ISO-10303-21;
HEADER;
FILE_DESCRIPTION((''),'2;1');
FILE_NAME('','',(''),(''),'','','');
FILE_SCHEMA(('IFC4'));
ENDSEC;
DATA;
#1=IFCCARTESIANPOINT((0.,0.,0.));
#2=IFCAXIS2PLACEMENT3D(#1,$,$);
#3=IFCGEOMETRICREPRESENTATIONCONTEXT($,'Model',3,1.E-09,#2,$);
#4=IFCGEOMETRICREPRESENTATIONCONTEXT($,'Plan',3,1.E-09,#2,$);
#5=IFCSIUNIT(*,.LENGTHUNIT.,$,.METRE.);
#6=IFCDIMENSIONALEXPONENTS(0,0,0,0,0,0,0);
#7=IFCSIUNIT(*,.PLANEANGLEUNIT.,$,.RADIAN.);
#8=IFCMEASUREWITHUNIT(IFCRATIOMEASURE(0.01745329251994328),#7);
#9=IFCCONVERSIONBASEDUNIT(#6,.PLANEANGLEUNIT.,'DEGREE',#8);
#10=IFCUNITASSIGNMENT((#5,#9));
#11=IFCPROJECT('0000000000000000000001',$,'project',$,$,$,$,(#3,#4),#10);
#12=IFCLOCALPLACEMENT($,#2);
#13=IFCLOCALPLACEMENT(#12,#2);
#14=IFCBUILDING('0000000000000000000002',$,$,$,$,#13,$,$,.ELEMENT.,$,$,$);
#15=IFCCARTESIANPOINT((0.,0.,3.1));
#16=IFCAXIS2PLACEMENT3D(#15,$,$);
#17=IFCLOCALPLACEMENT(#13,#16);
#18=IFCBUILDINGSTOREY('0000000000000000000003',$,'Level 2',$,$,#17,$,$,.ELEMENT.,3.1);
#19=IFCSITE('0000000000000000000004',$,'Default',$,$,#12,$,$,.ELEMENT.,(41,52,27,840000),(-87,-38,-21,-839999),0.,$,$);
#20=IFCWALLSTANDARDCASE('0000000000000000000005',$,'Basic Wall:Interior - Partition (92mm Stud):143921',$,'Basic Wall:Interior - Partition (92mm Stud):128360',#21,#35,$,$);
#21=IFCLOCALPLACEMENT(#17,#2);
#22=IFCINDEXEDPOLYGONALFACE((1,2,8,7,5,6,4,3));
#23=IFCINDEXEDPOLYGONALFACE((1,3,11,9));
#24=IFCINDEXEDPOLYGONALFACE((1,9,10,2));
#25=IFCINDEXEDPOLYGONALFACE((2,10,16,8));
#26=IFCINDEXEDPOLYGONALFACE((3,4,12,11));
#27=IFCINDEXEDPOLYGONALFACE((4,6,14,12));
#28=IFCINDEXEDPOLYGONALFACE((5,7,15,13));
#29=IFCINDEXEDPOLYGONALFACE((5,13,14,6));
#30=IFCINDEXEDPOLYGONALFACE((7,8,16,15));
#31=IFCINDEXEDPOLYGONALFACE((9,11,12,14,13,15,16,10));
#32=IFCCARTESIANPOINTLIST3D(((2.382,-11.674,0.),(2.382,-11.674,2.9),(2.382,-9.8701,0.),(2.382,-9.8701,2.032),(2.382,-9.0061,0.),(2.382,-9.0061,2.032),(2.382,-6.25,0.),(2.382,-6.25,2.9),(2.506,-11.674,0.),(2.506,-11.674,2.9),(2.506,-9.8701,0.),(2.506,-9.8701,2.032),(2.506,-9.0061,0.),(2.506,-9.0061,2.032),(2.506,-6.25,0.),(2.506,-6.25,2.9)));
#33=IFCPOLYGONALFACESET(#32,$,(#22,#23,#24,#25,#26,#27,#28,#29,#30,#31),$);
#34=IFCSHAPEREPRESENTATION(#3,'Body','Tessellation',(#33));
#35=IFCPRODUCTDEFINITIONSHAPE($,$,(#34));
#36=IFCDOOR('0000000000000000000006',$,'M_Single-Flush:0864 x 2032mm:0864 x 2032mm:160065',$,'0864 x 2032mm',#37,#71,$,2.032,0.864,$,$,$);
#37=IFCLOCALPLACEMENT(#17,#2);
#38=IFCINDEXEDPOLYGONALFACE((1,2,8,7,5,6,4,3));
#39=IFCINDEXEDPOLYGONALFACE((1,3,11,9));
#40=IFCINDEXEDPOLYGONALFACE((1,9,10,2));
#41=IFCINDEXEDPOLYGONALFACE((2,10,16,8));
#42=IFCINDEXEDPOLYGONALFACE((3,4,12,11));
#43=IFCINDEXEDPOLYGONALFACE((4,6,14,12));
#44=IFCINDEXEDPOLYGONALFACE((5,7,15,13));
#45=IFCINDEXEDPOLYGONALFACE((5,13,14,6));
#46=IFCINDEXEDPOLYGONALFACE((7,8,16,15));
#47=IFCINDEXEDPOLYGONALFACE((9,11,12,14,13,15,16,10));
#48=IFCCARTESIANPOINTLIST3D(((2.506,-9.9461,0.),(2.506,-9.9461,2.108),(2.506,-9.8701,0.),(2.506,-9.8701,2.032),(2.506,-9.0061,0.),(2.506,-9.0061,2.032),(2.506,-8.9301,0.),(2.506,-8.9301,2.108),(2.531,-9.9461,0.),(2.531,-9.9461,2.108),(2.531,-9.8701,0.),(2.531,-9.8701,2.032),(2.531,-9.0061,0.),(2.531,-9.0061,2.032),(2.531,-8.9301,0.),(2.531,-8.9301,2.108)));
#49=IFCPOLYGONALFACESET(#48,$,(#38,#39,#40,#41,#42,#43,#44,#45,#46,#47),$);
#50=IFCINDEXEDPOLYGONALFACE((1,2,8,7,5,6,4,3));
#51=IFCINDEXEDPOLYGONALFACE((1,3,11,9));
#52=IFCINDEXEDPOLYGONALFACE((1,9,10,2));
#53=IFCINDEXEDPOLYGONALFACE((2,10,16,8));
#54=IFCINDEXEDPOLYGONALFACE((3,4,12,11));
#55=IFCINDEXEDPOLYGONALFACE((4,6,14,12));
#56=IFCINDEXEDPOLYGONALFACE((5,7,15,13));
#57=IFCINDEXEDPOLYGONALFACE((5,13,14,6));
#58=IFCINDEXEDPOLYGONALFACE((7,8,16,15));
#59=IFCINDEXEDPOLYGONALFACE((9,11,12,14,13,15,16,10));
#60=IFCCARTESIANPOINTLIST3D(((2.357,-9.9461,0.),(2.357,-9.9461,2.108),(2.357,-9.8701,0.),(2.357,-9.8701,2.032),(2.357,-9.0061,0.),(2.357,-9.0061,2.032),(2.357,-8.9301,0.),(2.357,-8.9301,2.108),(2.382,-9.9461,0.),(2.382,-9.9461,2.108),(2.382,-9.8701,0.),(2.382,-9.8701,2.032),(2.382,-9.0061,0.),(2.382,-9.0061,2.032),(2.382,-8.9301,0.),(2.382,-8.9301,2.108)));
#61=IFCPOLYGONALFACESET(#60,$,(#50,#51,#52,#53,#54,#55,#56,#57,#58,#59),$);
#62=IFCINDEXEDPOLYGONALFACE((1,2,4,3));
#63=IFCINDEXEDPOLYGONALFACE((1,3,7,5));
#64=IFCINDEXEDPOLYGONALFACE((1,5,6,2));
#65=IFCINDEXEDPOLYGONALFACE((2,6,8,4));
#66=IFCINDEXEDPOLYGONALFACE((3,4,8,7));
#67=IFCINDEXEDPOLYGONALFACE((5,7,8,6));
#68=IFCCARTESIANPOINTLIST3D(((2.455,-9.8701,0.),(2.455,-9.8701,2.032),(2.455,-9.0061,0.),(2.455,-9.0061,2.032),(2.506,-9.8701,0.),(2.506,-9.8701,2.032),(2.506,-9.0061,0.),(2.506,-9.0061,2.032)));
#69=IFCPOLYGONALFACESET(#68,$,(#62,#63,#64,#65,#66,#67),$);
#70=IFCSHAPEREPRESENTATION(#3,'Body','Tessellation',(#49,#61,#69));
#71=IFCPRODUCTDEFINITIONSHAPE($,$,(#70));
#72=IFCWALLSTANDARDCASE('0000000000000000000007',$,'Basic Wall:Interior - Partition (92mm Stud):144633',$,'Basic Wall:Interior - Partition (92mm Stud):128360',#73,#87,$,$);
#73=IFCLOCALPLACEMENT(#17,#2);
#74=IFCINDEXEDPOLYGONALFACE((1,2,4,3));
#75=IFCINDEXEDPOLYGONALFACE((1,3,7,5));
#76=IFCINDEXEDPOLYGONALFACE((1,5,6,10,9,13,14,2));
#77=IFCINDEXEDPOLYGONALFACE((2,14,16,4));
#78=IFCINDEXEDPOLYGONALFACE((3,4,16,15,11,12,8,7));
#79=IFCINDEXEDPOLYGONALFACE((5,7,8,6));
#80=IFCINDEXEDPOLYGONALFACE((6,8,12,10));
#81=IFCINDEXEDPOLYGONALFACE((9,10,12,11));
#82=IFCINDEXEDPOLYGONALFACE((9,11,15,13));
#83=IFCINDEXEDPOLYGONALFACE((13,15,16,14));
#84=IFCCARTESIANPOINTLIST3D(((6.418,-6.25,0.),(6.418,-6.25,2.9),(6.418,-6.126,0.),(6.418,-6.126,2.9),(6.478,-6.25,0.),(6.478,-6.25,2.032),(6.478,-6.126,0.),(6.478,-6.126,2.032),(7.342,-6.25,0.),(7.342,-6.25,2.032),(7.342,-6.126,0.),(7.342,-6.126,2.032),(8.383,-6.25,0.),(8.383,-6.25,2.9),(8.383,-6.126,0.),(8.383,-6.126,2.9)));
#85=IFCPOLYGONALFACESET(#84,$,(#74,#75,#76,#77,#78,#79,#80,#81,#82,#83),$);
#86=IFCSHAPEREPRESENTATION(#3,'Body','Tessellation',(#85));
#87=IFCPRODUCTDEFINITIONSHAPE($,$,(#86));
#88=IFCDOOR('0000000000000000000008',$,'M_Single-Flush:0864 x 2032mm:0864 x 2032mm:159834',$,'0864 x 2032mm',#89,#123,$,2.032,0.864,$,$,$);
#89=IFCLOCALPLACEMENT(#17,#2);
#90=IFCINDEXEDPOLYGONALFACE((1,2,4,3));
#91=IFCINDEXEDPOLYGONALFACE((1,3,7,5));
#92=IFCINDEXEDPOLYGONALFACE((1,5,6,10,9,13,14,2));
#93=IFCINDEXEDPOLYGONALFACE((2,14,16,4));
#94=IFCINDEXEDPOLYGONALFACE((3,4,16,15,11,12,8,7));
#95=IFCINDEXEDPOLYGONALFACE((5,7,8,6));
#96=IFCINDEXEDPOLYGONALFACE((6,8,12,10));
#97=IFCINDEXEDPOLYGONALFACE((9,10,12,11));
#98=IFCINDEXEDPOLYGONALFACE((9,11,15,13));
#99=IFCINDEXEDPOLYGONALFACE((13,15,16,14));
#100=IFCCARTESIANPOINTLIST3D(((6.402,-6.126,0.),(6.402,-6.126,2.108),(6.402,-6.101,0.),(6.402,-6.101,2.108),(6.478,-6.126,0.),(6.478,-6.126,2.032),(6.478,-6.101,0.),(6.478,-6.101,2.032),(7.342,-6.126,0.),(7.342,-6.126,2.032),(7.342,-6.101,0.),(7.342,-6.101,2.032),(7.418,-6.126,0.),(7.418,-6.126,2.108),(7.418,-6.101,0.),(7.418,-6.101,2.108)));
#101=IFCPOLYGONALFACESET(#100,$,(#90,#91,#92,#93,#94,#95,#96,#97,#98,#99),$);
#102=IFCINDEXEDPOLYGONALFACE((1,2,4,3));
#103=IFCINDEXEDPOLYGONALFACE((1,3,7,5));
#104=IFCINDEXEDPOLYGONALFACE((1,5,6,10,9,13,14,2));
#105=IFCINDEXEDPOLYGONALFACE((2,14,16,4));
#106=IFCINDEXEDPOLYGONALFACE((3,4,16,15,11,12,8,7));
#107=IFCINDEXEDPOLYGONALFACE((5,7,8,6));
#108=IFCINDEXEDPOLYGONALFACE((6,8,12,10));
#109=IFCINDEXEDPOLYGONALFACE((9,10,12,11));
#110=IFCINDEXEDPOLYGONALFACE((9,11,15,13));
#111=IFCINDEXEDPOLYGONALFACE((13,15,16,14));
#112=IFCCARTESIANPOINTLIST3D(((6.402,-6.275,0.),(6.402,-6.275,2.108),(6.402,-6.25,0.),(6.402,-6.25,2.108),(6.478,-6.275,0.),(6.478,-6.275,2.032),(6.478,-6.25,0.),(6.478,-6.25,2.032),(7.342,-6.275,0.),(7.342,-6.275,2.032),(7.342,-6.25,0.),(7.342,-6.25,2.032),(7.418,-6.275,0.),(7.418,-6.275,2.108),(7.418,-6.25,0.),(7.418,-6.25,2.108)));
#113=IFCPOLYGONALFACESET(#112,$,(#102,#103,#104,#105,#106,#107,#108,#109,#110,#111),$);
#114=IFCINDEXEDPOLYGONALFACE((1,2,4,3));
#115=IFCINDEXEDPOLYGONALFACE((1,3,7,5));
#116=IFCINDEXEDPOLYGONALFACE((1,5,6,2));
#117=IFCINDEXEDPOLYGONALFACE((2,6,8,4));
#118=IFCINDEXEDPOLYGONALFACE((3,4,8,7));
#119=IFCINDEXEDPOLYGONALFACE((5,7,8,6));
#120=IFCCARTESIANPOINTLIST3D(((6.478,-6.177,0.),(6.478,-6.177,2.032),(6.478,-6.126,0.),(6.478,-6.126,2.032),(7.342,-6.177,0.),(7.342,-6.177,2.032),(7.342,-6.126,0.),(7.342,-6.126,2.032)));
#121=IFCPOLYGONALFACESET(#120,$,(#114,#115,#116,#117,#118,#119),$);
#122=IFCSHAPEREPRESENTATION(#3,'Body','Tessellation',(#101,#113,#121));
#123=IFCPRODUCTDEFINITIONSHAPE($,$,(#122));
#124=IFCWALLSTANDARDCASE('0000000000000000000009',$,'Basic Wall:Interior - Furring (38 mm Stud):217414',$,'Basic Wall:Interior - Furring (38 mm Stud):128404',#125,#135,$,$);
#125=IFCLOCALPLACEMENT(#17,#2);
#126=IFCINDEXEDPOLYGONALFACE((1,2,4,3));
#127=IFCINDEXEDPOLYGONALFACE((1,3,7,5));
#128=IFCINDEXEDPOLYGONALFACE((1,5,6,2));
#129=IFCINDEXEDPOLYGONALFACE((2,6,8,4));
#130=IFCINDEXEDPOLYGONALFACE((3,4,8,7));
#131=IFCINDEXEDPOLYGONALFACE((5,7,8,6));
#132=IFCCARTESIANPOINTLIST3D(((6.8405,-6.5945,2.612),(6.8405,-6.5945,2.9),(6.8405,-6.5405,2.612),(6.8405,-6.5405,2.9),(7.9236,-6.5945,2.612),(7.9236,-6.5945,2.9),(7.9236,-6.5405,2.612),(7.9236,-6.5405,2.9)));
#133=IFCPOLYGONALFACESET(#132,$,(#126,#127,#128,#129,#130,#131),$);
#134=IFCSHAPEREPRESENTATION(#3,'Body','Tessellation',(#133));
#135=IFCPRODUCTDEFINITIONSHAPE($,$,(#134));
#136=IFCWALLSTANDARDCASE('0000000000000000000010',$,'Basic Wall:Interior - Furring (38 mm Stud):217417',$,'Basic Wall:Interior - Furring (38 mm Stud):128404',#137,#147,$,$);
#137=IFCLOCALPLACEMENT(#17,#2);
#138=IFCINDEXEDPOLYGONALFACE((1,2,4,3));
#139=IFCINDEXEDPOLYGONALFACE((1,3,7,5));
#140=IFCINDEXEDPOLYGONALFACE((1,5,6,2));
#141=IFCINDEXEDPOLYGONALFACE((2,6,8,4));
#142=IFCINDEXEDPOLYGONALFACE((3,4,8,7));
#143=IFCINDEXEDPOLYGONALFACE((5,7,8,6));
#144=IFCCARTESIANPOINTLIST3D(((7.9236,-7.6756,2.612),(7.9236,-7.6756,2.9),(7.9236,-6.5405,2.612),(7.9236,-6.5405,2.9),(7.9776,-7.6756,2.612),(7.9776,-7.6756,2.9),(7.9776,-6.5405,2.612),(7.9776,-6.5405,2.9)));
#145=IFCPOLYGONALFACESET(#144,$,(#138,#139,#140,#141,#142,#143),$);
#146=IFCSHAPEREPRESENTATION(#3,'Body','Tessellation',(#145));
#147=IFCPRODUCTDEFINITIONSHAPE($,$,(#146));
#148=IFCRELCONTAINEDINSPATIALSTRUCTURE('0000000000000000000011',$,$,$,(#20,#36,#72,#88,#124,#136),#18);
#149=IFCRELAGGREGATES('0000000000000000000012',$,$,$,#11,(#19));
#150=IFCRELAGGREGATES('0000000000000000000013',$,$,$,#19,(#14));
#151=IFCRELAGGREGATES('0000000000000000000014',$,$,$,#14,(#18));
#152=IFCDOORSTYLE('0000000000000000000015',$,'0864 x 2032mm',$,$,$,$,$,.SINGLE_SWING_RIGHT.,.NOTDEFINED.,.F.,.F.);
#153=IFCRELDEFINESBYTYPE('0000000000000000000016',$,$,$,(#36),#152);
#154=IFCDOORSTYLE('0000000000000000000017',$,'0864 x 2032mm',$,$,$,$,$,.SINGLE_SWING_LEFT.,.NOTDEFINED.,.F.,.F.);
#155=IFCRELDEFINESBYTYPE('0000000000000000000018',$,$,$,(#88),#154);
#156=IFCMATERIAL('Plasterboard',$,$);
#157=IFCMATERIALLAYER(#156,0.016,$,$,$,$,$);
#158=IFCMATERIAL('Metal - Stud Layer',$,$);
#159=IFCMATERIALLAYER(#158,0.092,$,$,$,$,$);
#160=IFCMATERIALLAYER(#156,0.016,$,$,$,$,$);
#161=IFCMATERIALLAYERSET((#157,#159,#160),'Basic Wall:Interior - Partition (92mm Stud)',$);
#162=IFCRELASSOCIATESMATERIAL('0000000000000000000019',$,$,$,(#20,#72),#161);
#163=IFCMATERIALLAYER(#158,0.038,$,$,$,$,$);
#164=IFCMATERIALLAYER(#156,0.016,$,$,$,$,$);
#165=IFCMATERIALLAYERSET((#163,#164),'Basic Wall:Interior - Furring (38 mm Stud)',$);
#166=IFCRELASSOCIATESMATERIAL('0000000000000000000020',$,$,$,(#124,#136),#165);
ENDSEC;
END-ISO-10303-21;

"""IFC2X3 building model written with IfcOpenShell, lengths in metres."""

from ifc_helpers import new_model, entity, si_unit, converted_unit, frame, frame_2d, origin, origin_2d_with_axis, place, context, project, spatial, polyline, rectangle, outline, extrude, source, transform, mapped, material, layer, layer_set, layer_usage, type_object, type_shapes, element, fill, save


model = new_model("IFC2X3")

# Units and contexts
model_context = context("Model", 3, precision=1e-09, world=origin())
plan_context = context("Plan", 3, precision=1e-09, world=origin())
ifc_project = project(units=[si_unit("LENGTHUNIT", "METRE"), converted_unit("PLANEANGLEUNIT", "DEGREE", entity("IfcRatioMeasure", 0.01745329251994328), si_unit("PLANEANGLEUNIT", "RADIAN"), dimensions=[0, 0, 0, 0, 0, 0, 0])], contexts=[model_context, plan_context])

# Site, building, storey
site_placement = place(None, origin())
site = spatial("IfcSite", under=ifc_project, at=site_placement, Name="Default", CompositionType="ELEMENT", RefLatitude=(41, 52, 27, 840000), RefLongitude=(-87, -38, -21, -839999), RefElevation=0.0)
building_placement = place(site_placement, origin())
building = spatial("IfcBuilding", under=site, at=building_placement, CompositionType="ELEMENT")
storey_placement = place(building_placement, frame((0.0, 0.0, 3.1)))
storey = spatial("IfcBuildingStorey", under=building, at=storey_placement, Name="Level 2", CompositionType="ELEMENT", Elevation=3.1)

# Shared definitions
ifc_material_1 = material(Name="Metal - Stud Layer")
ifc_material_2 = material(Name="Plasterboard")

# Walls, openings, doors
ifc_layer_1 = layer(ifc_material_2, 0.016)
ifc_layer_2 = layer(ifc_material_1, 0.092)
ifc_layer_3 = layer(ifc_material_2, 0.016)
ifc_layer_set_1 = layer_set([ifc_layer_1, ifc_layer_2, ifc_layer_3], Name="Basic Wall:Interior - Partition (92mm Stud)")
ifc_layer_usage_1 = layer_usage(ifc_layer_set_1, "AXIS2", "NEGATIVE", 0.062)
wall_1_placement = place(storey_placement, frame((2.444, -6.25, 0.0), z_axis=(0.0, 0.0, 1.0), x_axis=(0.0, -1.0, 0.0)))
wall_1 = element("IfcWallStandardCase", 1, at=wall_1_placement, inside=storey, material=ifc_layer_usage_1, Name="Basic Wall:Interior - Partition (92mm Stud):143921", ObjectType="Basic Wall:Interior - Partition (92mm Stud):128360", context=model_context, shape_type="SweptSolid", body=[
    extrude(rectangle(XDim=5.424, YDim=0.124, at=frame_2d((2.712, 0.0), x_axis=(-1.0, 0.0))), origin(), (0.0, 0.0, 1.0), 2.9),
])
opening_1_placement = place(wall_1_placement, frame((2.7561, -0.062, 0.0)))
opening_1 = element("IfcOpeningElement", 2, at=opening_1_placement, cuts=wall_1, ObjectType="Opening", context=model_context, shape_type="SweptSolid", body=[
    extrude(rectangle(XDim=0.864, YDim=2.032, at=frame_2d((1.016, 0.432), x_axis=(0.0, 1.0))), frame((0.0, 0.0, 0.0), z_axis=(0.0, 1.0, 0.0), x_axis=(0.0, 0.0, 1.0)), (0.0, 0.0, 1.0), 0.124),
])
door_style_1 = type_object("IfcDoorStyle", Name="0864 x 2032mm", ConstructionType="NOTDEFINED", OperationType="SINGLE_SWING_RIGHT", ParameterTakesPrecedence=False, Sizeable=False)
shared_shape_1 = source(origin(), model_context, "Body", "SweptSolid", [
    extrude(outline(polyline([(-0.508, -1.073), (0.508, -1.073), (0.508, 1.035), (0.432, 1.035), (0.432, -0.997), (-0.432, -0.997), (-0.432, 1.035), (-0.508, 1.035), (-0.508, -1.073)])), frame((0.432, 0.124, 1.035), z_axis=(0.0, 1.0, 0.0), x_axis=(1.0, 0.0, 0.0)), (0.0, 0.0, 1.0), 0.025),
    extrude(outline(polyline([(-1.073, -0.508), (1.035, -0.508), (1.035, -0.432), (-0.997, -0.432), (-0.997, 0.432), (1.035, 0.432), (1.035, 0.508), (-1.073, 0.508), (-1.073, -0.508)])), frame((0.432, -0.025, 1.035), z_axis=(0.0, 1.0, 0.0), x_axis=(0.0, 0.0, -1.0)), (0.0, 0.0, 1.0), 0.025),
    extrude(rectangle(XDim=0.051, YDim=0.864, at=origin_2d_with_axis()), frame((0.432, 0.0985, 0.0), z_axis=(0.0, 0.0, 1.0), x_axis=(0.0, 1.0, 0.0)), (0.0, 0.0, 1.0), 2.032),
])
type_shapes(door_style_1, [shared_shape_1])
door_1_placement = place(opening_1_placement, origin())
door_1 = element("IfcDoor", 3, at=door_1_placement, inside=storey, type_object=door_style_1, Name="M_Single-Flush:0864 x 2032mm:0864 x 2032mm:160065", ObjectType="0864 x 2032mm", OverallHeight=2.032, OverallWidth=0.864, context=model_context, shape_type="MappedRepresentation", body=[
    mapped(shared_shape_1, transform((0.0, 0.0, 0.0), scale=1.0)),
])
fill(opening_1, door_1)
ifc_layer_usage_2 = layer_usage(ifc_layer_set_1, "AXIS2", "NEGATIVE", 0.062)
wall_2_placement = place(storey_placement, frame((6.418, -6.188, 0.0)))
wall_2 = element("IfcWallStandardCase", 4, at=wall_2_placement, inside=storey, material=ifc_layer_usage_2, Name="Basic Wall:Interior - Partition (92mm Stud):144633", ObjectType="Basic Wall:Interior - Partition (92mm Stud):128360", context=model_context, shape_type="SweptSolid", body=[
    extrude(rectangle(XDim=1.965, YDim=0.124, at=frame_2d((0.9825, 0.0), x_axis=(-1.0, 0.0))), origin(), (0.0, 0.0, 1.0), 2.9),
])
opening_2_placement = place(wall_2_placement, frame((0.06, -0.062, 0.0)))
opening_2 = element("IfcOpeningElement", 5, at=opening_2_placement, cuts=wall_2, ObjectType="Opening", context=model_context, shape_type="SweptSolid", body=[
    extrude(rectangle(XDim=0.864, YDim=2.032, at=frame_2d((1.016, 0.432), x_axis=(0.0, -1.0))), frame((0.0, 0.0, 0.0), z_axis=(0.0, 1.0, 0.0), x_axis=(0.0, 0.0, 1.0)), (0.0, 0.0, 1.0), 0.124),
])
door_style_2 = type_object("IfcDoorStyle", Name="0864 x 2032mm", ConstructionType="NOTDEFINED", OperationType="SINGLE_SWING_LEFT", ParameterTakesPrecedence=False, Sizeable=False)
shared_shape_2 = source(origin(), model_context, "Body", "SweptSolid", [
    extrude(outline(polyline([(-0.508, -1.073), (0.508, -1.073), (0.508, 1.035), (0.432, 1.035), (0.432, -0.997), (-0.432, -0.997), (-0.432, 1.035), (-0.508, 1.035), (-0.508, -1.073)])), frame((0.432, 0.149, 1.035), z_axis=(0.0, -1.0, 0.0), x_axis=(-1.0, 0.0, 0.0)), (0.0, 0.0, 1.0), 0.025),
    extrude(outline(polyline([(-1.073, -0.508), (1.035, -0.508), (1.035, -0.432), (-0.997, -0.432), (-0.997, 0.432), (1.035, 0.432), (1.035, 0.508), (-1.073, 0.508), (-1.073, -0.508)])), frame((0.432, 0.0, 1.035), z_axis=(0.0, -1.0, 0.0), x_axis=(0.0, 0.0, -1.0)), (0.0, 0.0, 1.0), 0.025),
    extrude(rectangle(XDim=0.864, YDim=0.051, at=origin_2d_with_axis()), frame((0.432, 0.0985, 0.0)), (0.0, 0.0, 1.0), 2.032),
])
type_shapes(door_style_2, [shared_shape_2])
door_2_placement = place(opening_2_placement, origin())
door_2 = element("IfcDoor", 6, at=door_2_placement, inside=storey, type_object=door_style_2, Name="M_Single-Flush:0864 x 2032mm:0864 x 2032mm:159834", ObjectType="0864 x 2032mm", OverallHeight=2.032, OverallWidth=0.864, context=model_context, shape_type="MappedRepresentation", body=[
    mapped(shared_shape_2, transform((0.0, 0.0, 0.0), scale=1.0)),
])
fill(opening_2, door_2)

# Walls
ifc_layer_4 = layer(ifc_material_1, 0.038)
ifc_layer_5 = layer(ifc_material_2, 0.016)
ifc_layer_set_2 = layer_set([ifc_layer_4, ifc_layer_5], Name="Basic Wall:Interior - Furring (38 mm Stud)")
ifc_layer_usage_3 = layer_usage(ifc_layer_set_2, "AXIS2", "NEGATIVE", 0.027)
wall_3_placement = place(storey_placement, frame((6.8405, -6.5675, 2.612)))
element("IfcWallStandardCase", 7, at=wall_3_placement, inside=storey, material=ifc_layer_usage_3, Name="Basic Wall:Interior - Furring (38 mm Stud):217414", ObjectType="Basic Wall:Interior - Furring (38 mm Stud):128404", context=model_context, shape_type="SweptSolid", body=[
    extrude(rectangle(XDim=1.0831, YDim=0.054, at=frame_2d((0.5416, 0.0), x_axis=(-1.0, 0.0))), origin(), (0.0, 0.0, 1.0), 0.288),
])
ifc_layer_usage_4 = layer_usage(ifc_layer_set_2, "AXIS2", "NEGATIVE", 0.027)
wall_4_placement = place(storey_placement, frame((7.9506, -6.5405, 2.612), z_axis=(0.0, 0.0, 1.0), x_axis=(0.0, -1.0, 0.0)))
element("IfcWallStandardCase", 8, at=wall_4_placement, inside=storey, material=ifc_layer_usage_4, Name="Basic Wall:Interior - Furring (38 mm Stud):217417", ObjectType="Basic Wall:Interior - Furring (38 mm Stud):128404", context=model_context, shape_type="SweptSolid", body=[
    extrude(rectangle(XDim=1.1351, YDim=0.054, at=frame_2d((0.5675, 0.0), x_axis=(-1.0, 0.0))), origin(), (0.0, 0.0, 1.0), 0.288),
])

save(model, "model.ifc")
